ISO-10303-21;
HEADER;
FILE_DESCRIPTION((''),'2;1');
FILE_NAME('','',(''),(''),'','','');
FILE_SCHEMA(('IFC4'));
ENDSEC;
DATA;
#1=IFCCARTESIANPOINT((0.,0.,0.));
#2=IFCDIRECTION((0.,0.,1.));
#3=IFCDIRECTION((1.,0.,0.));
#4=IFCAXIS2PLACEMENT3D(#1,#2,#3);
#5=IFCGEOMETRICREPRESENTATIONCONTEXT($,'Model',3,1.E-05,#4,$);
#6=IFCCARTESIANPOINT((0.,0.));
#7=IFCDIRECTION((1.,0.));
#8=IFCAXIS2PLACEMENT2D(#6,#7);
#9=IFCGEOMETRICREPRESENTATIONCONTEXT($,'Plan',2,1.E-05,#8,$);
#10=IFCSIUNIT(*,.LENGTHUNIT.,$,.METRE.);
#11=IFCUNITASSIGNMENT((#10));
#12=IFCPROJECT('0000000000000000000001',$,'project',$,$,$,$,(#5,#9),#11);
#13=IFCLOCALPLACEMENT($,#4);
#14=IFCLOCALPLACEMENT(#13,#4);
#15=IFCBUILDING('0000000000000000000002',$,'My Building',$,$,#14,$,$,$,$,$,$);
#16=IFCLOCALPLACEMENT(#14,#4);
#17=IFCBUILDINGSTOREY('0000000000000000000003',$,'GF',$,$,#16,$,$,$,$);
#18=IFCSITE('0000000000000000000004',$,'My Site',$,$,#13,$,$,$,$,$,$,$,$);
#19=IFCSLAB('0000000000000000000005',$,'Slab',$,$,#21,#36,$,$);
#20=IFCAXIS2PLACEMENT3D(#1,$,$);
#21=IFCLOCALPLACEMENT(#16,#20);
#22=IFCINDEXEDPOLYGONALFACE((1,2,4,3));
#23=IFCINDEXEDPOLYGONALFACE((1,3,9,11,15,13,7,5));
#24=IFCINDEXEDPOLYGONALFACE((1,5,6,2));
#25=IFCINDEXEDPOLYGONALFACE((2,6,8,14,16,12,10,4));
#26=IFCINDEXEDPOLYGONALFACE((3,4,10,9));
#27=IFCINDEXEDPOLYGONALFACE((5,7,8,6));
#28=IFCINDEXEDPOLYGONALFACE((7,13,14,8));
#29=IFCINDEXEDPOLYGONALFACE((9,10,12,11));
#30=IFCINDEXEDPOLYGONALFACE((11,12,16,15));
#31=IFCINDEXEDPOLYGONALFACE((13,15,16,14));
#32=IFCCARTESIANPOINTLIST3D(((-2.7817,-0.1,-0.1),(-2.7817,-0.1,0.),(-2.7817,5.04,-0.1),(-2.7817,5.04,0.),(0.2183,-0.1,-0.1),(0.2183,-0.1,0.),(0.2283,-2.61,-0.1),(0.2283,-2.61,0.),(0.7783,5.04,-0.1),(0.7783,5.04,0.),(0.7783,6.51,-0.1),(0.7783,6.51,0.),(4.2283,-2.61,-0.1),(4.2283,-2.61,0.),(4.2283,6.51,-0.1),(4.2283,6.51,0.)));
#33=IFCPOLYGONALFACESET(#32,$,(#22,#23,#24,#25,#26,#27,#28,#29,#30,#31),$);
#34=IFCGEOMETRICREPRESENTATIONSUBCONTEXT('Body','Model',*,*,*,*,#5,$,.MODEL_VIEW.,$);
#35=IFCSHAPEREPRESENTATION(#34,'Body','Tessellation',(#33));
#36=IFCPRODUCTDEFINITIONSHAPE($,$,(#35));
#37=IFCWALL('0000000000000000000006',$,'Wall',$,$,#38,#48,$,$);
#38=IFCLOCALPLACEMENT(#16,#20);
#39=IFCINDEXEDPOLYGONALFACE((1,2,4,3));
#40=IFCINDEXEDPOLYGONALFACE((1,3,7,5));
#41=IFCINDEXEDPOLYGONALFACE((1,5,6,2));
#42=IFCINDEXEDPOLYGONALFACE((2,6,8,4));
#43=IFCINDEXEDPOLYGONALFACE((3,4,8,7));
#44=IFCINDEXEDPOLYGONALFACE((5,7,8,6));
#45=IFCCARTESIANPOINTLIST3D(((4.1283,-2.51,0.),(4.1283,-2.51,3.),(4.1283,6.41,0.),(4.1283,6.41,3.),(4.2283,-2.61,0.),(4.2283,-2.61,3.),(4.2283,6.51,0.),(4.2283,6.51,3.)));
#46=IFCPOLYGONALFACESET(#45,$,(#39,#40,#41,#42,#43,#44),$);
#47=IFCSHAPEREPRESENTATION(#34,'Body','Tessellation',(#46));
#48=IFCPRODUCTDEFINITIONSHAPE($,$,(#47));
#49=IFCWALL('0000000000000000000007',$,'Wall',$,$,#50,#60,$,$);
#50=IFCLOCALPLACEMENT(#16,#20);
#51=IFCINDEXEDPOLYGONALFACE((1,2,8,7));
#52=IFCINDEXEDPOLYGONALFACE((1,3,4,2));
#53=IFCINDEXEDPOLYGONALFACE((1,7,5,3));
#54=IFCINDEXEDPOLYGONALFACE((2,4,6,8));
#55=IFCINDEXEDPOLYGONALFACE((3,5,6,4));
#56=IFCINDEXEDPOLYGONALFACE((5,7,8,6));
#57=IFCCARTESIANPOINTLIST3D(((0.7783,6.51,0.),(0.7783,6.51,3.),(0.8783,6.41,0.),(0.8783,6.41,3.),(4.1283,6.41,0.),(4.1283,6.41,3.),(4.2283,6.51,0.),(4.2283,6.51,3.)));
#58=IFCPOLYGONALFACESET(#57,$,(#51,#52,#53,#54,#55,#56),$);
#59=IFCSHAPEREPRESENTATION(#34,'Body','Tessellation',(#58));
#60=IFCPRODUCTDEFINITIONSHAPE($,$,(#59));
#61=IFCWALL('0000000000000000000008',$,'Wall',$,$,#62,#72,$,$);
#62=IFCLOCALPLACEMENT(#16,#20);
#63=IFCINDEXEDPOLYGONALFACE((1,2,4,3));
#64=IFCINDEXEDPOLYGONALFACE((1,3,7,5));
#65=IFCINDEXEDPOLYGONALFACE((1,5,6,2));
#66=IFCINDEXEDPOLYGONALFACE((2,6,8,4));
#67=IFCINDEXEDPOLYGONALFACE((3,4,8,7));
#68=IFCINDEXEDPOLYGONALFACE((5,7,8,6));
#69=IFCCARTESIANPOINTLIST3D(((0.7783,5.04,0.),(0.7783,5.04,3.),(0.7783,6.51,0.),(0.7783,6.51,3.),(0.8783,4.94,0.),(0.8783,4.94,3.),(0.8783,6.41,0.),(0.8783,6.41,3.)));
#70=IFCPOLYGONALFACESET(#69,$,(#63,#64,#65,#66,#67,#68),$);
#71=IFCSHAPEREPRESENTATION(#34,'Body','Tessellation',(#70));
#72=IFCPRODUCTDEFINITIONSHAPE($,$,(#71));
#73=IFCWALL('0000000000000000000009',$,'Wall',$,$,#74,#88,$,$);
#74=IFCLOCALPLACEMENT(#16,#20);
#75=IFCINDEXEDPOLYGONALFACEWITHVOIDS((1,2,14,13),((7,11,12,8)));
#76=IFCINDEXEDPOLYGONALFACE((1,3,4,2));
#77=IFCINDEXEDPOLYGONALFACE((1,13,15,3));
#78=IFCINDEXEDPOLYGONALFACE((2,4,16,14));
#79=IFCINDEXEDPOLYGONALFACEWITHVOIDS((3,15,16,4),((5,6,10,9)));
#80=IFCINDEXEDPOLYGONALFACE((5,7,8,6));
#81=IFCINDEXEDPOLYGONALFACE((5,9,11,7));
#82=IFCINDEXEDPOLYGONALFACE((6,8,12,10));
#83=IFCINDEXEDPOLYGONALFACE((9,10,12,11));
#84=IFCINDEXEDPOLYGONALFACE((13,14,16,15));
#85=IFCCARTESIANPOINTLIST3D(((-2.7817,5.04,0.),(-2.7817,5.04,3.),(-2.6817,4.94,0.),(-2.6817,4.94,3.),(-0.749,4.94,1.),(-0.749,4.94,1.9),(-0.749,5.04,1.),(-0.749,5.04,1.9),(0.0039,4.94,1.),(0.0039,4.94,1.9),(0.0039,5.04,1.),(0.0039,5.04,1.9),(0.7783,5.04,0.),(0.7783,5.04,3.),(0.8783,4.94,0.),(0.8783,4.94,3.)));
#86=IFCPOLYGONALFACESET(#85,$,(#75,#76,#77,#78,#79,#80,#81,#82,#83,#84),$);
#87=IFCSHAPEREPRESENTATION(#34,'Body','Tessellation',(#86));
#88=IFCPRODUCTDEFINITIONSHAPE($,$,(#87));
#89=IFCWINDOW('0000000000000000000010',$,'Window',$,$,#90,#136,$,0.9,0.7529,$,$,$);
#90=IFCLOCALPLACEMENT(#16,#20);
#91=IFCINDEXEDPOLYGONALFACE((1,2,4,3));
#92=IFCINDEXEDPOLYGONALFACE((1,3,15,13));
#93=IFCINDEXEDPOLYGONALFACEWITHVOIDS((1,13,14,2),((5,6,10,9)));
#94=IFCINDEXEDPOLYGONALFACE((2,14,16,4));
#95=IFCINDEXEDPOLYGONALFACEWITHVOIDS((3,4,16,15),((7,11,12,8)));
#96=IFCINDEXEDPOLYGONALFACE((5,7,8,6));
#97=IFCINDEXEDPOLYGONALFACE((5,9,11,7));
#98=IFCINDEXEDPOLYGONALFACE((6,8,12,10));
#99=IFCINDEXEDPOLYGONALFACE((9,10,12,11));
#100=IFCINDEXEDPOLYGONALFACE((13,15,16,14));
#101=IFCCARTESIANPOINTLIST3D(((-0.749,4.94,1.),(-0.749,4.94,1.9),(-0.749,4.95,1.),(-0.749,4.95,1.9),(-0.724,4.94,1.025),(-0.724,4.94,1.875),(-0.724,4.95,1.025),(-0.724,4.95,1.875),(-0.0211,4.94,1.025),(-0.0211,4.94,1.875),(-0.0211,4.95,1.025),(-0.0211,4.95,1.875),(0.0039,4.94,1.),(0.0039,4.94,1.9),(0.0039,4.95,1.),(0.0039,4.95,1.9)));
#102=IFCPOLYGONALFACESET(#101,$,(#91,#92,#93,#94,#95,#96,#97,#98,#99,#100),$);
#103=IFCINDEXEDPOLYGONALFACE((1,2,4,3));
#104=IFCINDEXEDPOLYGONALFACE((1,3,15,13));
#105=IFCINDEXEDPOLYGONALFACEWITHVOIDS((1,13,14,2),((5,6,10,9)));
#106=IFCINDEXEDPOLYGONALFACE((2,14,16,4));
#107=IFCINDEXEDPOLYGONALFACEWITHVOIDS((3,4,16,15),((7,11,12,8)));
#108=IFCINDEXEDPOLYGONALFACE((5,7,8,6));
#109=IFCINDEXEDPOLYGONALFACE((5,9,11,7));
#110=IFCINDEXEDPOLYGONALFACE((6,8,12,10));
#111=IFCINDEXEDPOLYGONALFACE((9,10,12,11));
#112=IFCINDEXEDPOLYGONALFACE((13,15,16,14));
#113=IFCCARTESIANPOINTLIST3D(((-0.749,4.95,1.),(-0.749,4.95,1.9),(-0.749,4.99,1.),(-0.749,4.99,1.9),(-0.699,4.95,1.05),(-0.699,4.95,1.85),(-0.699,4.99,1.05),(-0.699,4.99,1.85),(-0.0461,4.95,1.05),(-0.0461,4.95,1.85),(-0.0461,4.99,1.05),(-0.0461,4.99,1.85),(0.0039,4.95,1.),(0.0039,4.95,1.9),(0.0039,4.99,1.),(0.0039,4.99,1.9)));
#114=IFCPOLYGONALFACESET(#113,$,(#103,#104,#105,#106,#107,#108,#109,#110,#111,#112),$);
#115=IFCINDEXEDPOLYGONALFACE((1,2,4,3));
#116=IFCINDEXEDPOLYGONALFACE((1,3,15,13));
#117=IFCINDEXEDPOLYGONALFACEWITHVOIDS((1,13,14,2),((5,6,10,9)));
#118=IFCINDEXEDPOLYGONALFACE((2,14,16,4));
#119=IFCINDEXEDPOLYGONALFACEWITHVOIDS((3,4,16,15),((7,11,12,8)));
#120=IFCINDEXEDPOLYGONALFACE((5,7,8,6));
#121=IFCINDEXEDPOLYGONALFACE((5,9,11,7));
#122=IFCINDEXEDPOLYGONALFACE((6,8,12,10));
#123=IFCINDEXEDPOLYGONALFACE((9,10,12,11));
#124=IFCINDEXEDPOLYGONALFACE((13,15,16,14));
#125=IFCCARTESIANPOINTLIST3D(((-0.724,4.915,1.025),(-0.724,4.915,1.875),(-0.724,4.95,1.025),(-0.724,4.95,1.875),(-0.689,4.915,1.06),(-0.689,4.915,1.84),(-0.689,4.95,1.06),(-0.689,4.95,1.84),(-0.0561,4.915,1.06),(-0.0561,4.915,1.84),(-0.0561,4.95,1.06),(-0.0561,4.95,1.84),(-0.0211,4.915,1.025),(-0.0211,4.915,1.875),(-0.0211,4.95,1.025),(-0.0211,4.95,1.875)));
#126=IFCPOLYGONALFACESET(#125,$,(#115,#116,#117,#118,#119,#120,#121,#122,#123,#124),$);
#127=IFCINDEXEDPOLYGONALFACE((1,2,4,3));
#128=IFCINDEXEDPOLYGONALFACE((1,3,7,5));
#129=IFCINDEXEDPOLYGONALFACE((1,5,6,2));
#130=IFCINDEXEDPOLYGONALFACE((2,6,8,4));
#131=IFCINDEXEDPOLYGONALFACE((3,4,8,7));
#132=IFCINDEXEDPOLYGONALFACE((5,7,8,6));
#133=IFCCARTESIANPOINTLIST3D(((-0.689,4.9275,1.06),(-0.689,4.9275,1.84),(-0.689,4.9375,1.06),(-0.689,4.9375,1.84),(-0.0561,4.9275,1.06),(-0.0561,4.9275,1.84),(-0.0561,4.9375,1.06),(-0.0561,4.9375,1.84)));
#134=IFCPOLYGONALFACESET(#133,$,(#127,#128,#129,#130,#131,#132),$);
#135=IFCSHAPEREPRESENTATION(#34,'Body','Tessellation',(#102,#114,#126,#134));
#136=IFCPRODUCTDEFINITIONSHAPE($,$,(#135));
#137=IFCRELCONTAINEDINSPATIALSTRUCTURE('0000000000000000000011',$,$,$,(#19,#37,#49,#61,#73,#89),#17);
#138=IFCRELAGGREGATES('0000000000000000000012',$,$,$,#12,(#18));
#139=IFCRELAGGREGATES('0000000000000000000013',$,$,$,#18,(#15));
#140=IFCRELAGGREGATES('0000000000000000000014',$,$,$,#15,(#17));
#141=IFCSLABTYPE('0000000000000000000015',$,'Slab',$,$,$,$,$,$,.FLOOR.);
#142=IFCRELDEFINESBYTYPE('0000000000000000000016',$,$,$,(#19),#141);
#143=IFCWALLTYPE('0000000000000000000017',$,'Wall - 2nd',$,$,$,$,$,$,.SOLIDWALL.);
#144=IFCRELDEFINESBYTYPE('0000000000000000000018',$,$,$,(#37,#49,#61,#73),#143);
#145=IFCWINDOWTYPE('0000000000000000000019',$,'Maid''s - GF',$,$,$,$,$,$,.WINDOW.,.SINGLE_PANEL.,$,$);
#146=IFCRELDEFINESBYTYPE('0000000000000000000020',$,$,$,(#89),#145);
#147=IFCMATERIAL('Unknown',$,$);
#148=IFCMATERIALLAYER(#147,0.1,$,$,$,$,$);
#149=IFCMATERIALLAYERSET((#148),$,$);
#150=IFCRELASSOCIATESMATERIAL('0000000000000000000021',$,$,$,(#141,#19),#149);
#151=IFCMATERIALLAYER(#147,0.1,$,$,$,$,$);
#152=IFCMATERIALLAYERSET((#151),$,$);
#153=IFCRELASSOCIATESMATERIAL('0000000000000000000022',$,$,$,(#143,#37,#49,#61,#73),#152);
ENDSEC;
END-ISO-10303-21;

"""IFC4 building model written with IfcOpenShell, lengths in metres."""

from ifc_helpers import new_model, entity, si_unit, frame, origin_with_axes, origin_2d_with_axis, place, context, subcontext, project, spatial, line, indexed_curve, outline, extrude, shape, source, transform, mapped, material, layer, layer_set, layer_usage, type_object, type_shapes, element, fill, save


model = new_model("IFC4")

# Units and contexts
model_context = context("Model", 3, precision=1e-05, world=origin_with_axes())
plan_context = context("Plan", 2, precision=1e-05, world=origin_2d_with_axis())
body_context_1 = subcontext(model_context, "Body", "Model", "MODEL_VIEW")
body_context_2 = subcontext(plan_context, "Body", "Plan", "PLAN_VIEW")
ifc_project = project(units=[si_unit("LENGTHUNIT", "METRE")], contexts=[model_context, plan_context])

# Site, building, storey
site_placement = place(None, origin_with_axes())
site = spatial("IfcSite", under=ifc_project, at=site_placement, Name="My Site")
building_placement = place(site_placement, origin_with_axes())
building = spatial("IfcBuilding", under=site, at=building_placement, Name="My Building")
storey_placement = place(building_placement, origin_with_axes())
storey = spatial("IfcBuildingStorey", under=building, at=storey_placement, Name="GF")

# Slab
ifc_material = material(Name="Unknown")
ifc_layer_1 = layer(ifc_material, 0.1)
ifc_layer_set_1 = layer_set([ifc_layer_1])
ifc_layer_usage_1 = layer_usage(ifc_layer_set_1, "AXIS3", "POSITIVE", -0.1)
slab_type = type_object("IfcSlabType", Name="Slab", PredefinedType="FLOOR", material=ifc_layer_set_1)
slab_placement = place(storey_placement, frame((0.2283, -2.61, 0.0), z_axis=(0.0, 0.0, 1.0), x_axis=(1.0, 0.0, 0.0)))
element("IfcSlab", 1, at=slab_placement, inside=storey, type_object=slab_type, material=ifc_layer_usage_1, Name="Slab", context=body_context_1, shape_type="SweptSolid", body=[
    extrude(outline(indexed_curve([(0.0, 0.0), (4.0, 0.0), (4.0, 9.12), (0.55, 9.12), (0.55, 7.65), (-3.01, 7.65), (-3.01, 2.51), (-0.01, 2.51), (0.0, 0.0)])), frame((0.0, 0.0, -0.1), z_axis=(0.0, 0.0, 1.0), x_axis=(1.0, 0.0, 0.0)), (0.0, 0.0, 1.0), 0.1),
])

# Shared definitions
ifc_layer_2 = layer(ifc_material, 0.1)
ifc_layer_set_2 = layer_set([ifc_layer_2])
wall_type = type_object("IfcWallType", Name="Wall - 2nd", PredefinedType="SOLIDWALL", material=ifc_layer_set_2)

# Walls
ifc_layer_usage_2 = layer_usage(ifc_layer_set_2, "AXIS2", "POSITIVE", 0.0)
wall_1_placement = place(storey_placement, frame((4.2283, -2.61, 0.0), z_axis=(0.0, 0.0, 1.0), x_axis=(0.0, 1.0, 0.0)))
element("IfcWall", 2, at=wall_1_placement, inside=storey, type_object=wall_type, material=ifc_layer_usage_2, Name="Wall", context=body_context_1, shape_type="SweptSolid", body=[
    extrude(outline(indexed_curve([(0.0, 0.0), (0.1, 0.1), (9.02, 0.1), (9.12, 0.0)], segments=[line(1, 2, 3, 4, 1)])), origin_with_axes(), (0.0, 0.0, 1.0), 3.0),
])
ifc_layer_usage_3 = layer_usage(ifc_layer_set_2, "AXIS2", "POSITIVE", 0.0)
wall_2_placement = place(storey_placement, frame((4.2283, 6.51, 0.0), z_axis=(0.0, 0.0, 1.0), x_axis=(-1.0, 0.0, 0.0)))
element("IfcWall", 3, at=wall_2_placement, inside=storey, type_object=wall_type, material=ifc_layer_usage_3, Name="Wall", context=body_context_1, shape_type="SweptSolid", body=[
    extrude(outline(indexed_curve([(0.0, 0.0), (0.1, 0.1), (3.35, 0.1), (3.45, 0.0)], segments=[line(1, 2, 3, 4, 1)])), origin_with_axes(), (0.0, 0.0, 1.0), 3.0),
])
ifc_layer_usage_4 = layer_usage(ifc_layer_set_2, "AXIS2", "POSITIVE", 0.0)
wall_3_placement = place(storey_placement, frame((0.7783, 6.51, 0.0), z_axis=(0.0, 0.0, 1.0), x_axis=(0.0, -1.0, 0.0)))
element("IfcWall", 4, at=wall_3_placement, inside=storey, type_object=wall_type, material=ifc_layer_usage_4, Name="Wall", context=body_context_1, shape_type="SweptSolid", body=[
    extrude(outline(indexed_curve([(0.0, 0.0), (0.1, 0.1), (1.57, 0.1), (1.47, 0.0)], segments=[line(1, 2, 3, 4, 1)])), origin_with_axes(), (0.0, 0.0, 1.0), 3.0),
])

# Wall, opening, window
ifc_layer_usage_5 = layer_usage(ifc_layer_set_2, "AXIS2", "POSITIVE", 0.0)
wall_4_placement = place(storey_placement, frame((0.7783, 5.04, 0.0), z_axis=(0.0, 0.0, 1.0), x_axis=(-1.0, 0.0, 0.0)))
wall_4 = element("IfcWall", 5, at=wall_4_placement, inside=storey, type_object=wall_type, material=ifc_layer_usage_5, Name="Wall", context=body_context_1, shape_type="SweptSolid", body=[
    extrude(outline(indexed_curve([(0.0, 0.0), (-0.1, 0.1), (3.46, 0.1), (3.56, 0.0)], segments=[line(1, 2, 3, 4, 1)])), origin_with_axes(), (0.0, 0.0, 1.0), 3.0),
])
shared_shape_1 = source(origin_with_axes(), body_context_1, "Body", "SweptSolid", [
    extrude(outline(indexed_curve([(0.0, 0.0), (0.7529, 0.0), (0.7529, 0.9), (0.0, 0.9)], segments=[line(1, 2, 3, 4, 1)])), frame((0.0, -0.6, 0.0), z_axis=(0.0, -1.0, 0.0), x_axis=(1.0, 0.0, 0.0)), (0.0, 0.0, -1.0), 1.2),
])
opening_1_placement = place(wall_4_placement, frame((0.7744, 0.0, 1.0), z_axis=(0.0, 0.0, 1.0), x_axis=(1.0, 0.0, 0.0)))
opening_1 = element("IfcOpeningElement", 6, at=opening_1_placement, cuts=wall_4, PredefinedType="OPENING", context=body_context_1, shape_type="MappedRepresentation", body=[
    mapped(shared_shape_1, transform((0.0, 0.0, 0.0), x_axis=(1.0, 0.0, 0.0), y_axis=(0.0, 1.0, 0.0), z_axis=(0.0, 0.0, 1.0), scale=1.0)),
])
window_type_1 = type_object("IfcWindowType", Name="Maid's - GF", PartitioningType="SINGLE_PANEL", PredefinedType="WINDOW")
shared_shape_2 = source(origin_with_axes(), body_context_1, "Body", "SweptSolid", [
    extrude(outline(indexed_curve([(0.0, 0.0), (0.7529, 0.0), (0.7529, 0.9), (0.0, 0.9)], segments=[line(1, 2, 3, 4, 1)]), holes=[indexed_curve([(0.025, 0.025), (0.7279, 0.025), (0.7279, 0.875), (0.025, 0.875)], segments=[line(1, 2, 3, 4, 1)])]), frame((0.0, 0.09, 0.0), z_axis=(0.0, -1.0, 0.0), x_axis=(1.0, 0.0, 0.0)), (0.0, 0.0, -1.0), 0.01),
    extrude(outline(indexed_curve([(0.0, 0.0), (0.7529, 0.0), (0.7529, 0.9), (0.0, 0.9)], segments=[line(1, 2, 3, 4, 1)]), holes=[indexed_curve([(0.05, 0.05), (0.7029, 0.05), (0.7029, 0.85), (0.05, 0.85)], segments=[line(1, 2, 3, 4, 1)])]), frame((0.0, 0.05, 0.0), z_axis=(0.0, -1.0, 0.0), x_axis=(1.0, 0.0, 0.0)), (0.0, 0.0, -1.0), 0.04),
    extrude(outline(indexed_curve([(0.0, 0.0), (0.7029, 0.0), (0.7029, 0.85), (0.0, 0.85)], segments=[line(1, 2, 3, 4, 1)]), holes=[indexed_curve([(0.035, 0.035), (0.6679, 0.035), (0.6679, 0.815), (0.035, 0.815)], segments=[line(1, 2, 3, 4, 1)])]), frame((0.025, 0.09, 0.025), z_axis=(0.0, -1.0, 0.0), x_axis=(1.0, 0.0, 0.0)), (0.0, 0.0, -1.0), 0.035),
    extrude(outline(indexed_curve([(0.035, 0.035), (0.6679, 0.035), (0.6679, 0.815), (0.035, 0.815)], segments=[line(1, 2, 3, 4, 1)])), frame((0.025, 0.1025, 0.025), z_axis=(0.0, -1.0, 0.0), x_axis=(1.0, 0.0, 0.0)), (0.0, 0.0, -1.0), 0.01),
])
shared_shape_3 = source(origin_with_axes(), body_context_2, "Body", "Curve2D", [
    entity("IfcIndexedPolyCurve", entity("IfcCartesianPointList2D", [[0.05, 0.05], [0.7029, 0.05]])),
    entity("IfcIndexedPolyCurve", entity("IfcCartesianPointList2D", [[0.0, 0.1], [0.025, 0.1], [0.025, 0.09], [0.05, 0.09], [0.05, 0.05], [0.0, 0.05]]), [entity("IfcLineIndex", [1, 2, 3, 4, 5, 6, 1])]),
    entity("IfcIndexedPolyCurve", entity("IfcCartesianPointList2D", [[0.7529, 0.1], [0.7279, 0.1], [0.7279, 0.09], [0.7029, 0.09], [0.7029, 0.05], [0.7529, 0.05]]), [entity("IfcLineIndex", [1, 2, 3, 4, 5, 6, 1])]),
    entity("IfcIndexedPolyCurve", entity("IfcCartesianPointList2D", [[0.025, 0.09], [0.06, 0.09], [0.06, 0.125], [0.025, 0.125]]), [entity("IfcLineIndex", [1, 2, 3, 4, 1])]),
    entity("IfcIndexedPolyCurve", entity("IfcCartesianPointList2D", [[0.7279, 0.09], [0.6929, 0.09], [0.6929, 0.125], [0.7279, 0.125]]), [entity("IfcLineIndex", [1, 2, 3, 4, 1])]),
    entity("IfcIndexedPolyCurve", entity("IfcCartesianPointList2D", [[0.06, 0.09], [0.6929, 0.09]])),
    entity("IfcIndexedPolyCurve", entity("IfcCartesianPointList2D", [[0.06, 0.125], [0.6929, 0.125]])),
    entity("IfcIndexedPolyCurve", entity("IfcCartesianPointList2D", [[0.06, 0.1075], [0.6929, 0.1075]])),
])
type_shapes(window_type_1, [shared_shape_2, shared_shape_3])
window_1_placement = place(opening_1_placement, frame((0.0, 0.0, 0.0), z_axis=(0.0, 0.0, 1.0), x_axis=(1.0, 0.0, 0.0)))
window_1 = element("IfcWindow", 7, at=window_1_placement, inside=storey, type_object=window_type_1, Name="Window", OverallHeight=0.9, OverallWidth=0.7529, shapes=[
    shape(body_context_1, "Body", "MappedRepresentation", [mapped(shared_shape_2, transform((0.0, 0.0, 0.0), x_axis=(1.0, 0.0, 0.0), y_axis=(0.0, 1.0, 0.0), z_axis=(0.0, 0.0, 1.0), scale=1.0))]),
    shape(body_context_2, "Body", "MappedRepresentation", [mapped(shared_shape_3, transform((0.0, 0.0, 0.0), x_axis=(1.0, 0.0, 0.0), y_axis=(0.0, 1.0, 0.0), z_axis=(0.0, 0.0, 1.0), scale=1.0))]),
])
fill(opening_1, window_1)

save(model, "model.ifc")
